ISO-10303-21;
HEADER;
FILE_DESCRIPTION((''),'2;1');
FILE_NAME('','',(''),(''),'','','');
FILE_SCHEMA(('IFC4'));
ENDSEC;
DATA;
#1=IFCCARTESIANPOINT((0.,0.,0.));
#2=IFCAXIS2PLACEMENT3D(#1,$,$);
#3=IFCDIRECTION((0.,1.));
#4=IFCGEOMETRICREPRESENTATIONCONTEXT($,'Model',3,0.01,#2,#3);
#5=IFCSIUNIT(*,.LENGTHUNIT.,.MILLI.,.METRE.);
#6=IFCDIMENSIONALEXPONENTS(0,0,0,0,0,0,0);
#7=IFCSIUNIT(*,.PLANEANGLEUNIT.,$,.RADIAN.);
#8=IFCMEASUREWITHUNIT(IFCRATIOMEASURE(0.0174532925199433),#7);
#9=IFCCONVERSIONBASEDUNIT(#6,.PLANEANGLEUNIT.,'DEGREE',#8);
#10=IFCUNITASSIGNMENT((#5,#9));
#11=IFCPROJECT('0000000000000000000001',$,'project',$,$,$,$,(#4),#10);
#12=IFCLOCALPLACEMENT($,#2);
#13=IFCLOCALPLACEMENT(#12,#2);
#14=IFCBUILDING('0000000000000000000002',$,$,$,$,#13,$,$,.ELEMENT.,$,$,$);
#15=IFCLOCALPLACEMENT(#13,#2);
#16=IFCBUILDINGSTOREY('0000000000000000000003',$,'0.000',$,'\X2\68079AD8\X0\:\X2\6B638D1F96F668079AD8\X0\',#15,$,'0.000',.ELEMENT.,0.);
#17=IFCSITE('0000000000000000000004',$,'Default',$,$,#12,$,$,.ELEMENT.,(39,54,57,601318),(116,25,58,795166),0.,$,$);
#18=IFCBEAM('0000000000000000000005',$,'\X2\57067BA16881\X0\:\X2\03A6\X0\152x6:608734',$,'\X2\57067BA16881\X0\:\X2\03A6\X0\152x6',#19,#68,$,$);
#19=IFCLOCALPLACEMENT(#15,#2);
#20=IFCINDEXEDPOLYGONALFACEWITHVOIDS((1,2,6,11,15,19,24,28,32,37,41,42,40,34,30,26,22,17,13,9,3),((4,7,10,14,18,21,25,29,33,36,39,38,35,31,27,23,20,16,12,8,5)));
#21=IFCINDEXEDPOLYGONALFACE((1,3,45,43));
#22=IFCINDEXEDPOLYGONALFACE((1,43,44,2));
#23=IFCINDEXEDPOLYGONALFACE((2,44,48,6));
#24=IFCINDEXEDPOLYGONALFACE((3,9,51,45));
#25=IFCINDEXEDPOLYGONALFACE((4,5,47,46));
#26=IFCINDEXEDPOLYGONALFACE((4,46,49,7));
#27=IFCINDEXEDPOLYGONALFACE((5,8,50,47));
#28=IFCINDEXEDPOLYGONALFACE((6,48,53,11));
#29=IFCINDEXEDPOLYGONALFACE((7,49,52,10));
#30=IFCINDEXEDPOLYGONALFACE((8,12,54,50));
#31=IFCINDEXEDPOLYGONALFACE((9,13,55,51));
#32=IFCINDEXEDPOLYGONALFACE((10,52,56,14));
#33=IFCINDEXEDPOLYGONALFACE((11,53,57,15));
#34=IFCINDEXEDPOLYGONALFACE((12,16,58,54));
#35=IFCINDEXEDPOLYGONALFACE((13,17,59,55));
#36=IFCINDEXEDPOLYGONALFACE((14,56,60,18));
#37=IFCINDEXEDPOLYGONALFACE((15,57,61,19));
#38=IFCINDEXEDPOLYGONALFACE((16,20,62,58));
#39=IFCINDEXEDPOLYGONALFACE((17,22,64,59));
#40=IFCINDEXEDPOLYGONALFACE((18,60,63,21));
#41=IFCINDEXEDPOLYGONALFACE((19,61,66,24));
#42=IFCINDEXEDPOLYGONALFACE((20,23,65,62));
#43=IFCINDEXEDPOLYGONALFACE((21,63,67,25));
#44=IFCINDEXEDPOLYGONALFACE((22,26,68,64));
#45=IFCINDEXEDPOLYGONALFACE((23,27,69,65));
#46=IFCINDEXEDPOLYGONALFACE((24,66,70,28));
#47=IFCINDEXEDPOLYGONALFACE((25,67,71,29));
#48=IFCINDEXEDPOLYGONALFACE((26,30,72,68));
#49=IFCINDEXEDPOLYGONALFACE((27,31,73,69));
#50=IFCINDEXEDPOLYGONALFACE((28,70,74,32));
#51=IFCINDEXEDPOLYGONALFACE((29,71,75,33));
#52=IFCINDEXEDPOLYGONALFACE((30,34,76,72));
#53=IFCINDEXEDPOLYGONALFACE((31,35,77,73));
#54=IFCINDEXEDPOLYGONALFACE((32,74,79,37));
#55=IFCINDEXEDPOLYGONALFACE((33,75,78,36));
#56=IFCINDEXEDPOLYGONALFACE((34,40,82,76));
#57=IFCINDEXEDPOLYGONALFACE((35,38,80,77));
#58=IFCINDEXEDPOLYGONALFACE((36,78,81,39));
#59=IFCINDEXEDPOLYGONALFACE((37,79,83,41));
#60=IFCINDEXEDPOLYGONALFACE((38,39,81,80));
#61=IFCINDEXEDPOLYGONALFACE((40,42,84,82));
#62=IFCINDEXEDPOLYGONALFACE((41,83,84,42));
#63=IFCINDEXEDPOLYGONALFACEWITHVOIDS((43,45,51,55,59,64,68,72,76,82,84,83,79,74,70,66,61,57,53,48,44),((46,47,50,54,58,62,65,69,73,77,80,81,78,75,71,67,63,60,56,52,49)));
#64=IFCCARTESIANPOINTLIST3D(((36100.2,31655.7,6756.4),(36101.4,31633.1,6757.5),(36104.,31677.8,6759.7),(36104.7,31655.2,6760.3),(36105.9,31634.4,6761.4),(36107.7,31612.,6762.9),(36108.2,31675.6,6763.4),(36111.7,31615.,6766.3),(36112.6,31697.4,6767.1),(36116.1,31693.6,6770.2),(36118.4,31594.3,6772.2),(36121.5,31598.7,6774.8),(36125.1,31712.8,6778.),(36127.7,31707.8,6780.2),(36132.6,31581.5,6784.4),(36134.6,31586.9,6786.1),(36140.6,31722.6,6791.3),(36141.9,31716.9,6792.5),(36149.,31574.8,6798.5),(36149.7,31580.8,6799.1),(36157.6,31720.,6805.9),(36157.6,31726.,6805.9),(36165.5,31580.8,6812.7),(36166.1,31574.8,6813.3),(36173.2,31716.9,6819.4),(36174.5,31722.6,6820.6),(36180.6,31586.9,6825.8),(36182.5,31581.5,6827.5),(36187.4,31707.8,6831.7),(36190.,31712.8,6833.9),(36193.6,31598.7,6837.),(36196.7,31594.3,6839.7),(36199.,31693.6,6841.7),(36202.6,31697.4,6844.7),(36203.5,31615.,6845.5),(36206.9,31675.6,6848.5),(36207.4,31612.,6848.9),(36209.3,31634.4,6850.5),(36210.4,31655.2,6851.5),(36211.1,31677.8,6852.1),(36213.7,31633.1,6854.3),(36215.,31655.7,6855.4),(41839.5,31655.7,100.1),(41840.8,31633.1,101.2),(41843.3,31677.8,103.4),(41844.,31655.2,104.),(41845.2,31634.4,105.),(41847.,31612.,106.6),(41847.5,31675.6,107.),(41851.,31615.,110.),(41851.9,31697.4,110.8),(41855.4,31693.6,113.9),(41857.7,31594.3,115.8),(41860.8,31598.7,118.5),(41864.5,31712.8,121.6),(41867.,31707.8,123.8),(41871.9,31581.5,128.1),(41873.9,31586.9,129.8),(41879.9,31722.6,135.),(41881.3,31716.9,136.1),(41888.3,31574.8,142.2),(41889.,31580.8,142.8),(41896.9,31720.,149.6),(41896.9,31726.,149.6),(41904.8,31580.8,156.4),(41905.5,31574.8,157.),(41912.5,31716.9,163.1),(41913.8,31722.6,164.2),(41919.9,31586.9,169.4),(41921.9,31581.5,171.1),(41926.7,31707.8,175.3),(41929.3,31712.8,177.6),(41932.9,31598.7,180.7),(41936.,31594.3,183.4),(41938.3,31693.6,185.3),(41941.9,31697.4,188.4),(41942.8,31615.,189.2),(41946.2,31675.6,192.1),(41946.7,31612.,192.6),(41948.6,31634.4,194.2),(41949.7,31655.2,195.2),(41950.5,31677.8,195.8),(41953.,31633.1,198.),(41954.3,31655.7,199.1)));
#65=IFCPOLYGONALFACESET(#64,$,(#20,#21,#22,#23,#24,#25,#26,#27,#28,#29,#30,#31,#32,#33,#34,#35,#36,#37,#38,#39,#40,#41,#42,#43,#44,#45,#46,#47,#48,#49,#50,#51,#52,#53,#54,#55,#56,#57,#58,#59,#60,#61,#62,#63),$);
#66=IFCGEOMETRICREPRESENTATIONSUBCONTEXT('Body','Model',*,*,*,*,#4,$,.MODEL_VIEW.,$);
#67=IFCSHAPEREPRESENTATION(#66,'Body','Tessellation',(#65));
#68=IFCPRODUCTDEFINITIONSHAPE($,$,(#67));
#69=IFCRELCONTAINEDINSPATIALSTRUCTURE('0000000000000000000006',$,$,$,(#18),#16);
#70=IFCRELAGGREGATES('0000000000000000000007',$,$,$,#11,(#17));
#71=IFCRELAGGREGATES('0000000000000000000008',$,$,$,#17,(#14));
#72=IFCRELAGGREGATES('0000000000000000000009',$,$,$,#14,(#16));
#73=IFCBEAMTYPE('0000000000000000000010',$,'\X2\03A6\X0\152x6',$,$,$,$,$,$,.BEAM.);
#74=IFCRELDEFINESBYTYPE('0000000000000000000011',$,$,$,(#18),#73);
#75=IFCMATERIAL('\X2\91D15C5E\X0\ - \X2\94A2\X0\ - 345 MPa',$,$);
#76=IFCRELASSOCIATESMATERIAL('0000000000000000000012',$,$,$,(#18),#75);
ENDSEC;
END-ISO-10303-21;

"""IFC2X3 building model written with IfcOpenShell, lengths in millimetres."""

from ifc_helpers import new_model, entity, si_unit, converted_unit, direction, frame, frame_2d, origin, place, context, subcontext, project, spatial, hollow_circle, extrude, material, type_object, element, save


model = new_model("IFC2X3")

# Units and contexts
model_context = context("Model", 3, precision=0.01, world=origin(), true_north=direction((0.0, 1.0)))
body_context = subcontext(model_context, "Body", "Model", "MODEL_VIEW")
ifc_project = project(units=[si_unit("LENGTHUNIT", "METRE", prefix="MILLI"), converted_unit("PLANEANGLEUNIT", "DEGREE", entity("IfcRatioMeasure", 0.0174532925199433), si_unit("PLANEANGLEUNIT", "RADIAN"), dimensions=[0, 0, 0, 0, 0, 0, 0])], contexts=[model_context])

# Site, building, storey
site_placement = place(None, origin())
site = spatial("IfcSite", under=ifc_project, at=site_placement, Name="Default", CompositionType="ELEMENT", RefLatitude=(39, 54, 57, 601318), RefLongitude=(116, 25, 58, 795166), RefElevation=0.0)
building_placement = place(site_placement, origin())
building = spatial("IfcBuilding", under=site, at=building_placement, CompositionType="ELEMENT")
storey_placement = place(building_placement, origin())
storey = spatial("IfcBuildingStorey", under=building, at=storey_placement, Name="0.000", ObjectType="标高:正负零标高", LongName="0.000", CompositionType="ELEMENT", Elevation=0.0)

# Shared definitions
ifc_material_1 = material(Name="金属 - 钢 - 345 MPa")

# Beam
beam_type_1 = type_object("IfcBeamType", Name="Φ152x6", PredefinedType="BEAM")
beam_1_placement = place(storey_placement, frame((41861.8, 31650.0, -116.0), z_axis=(0.757348, 0.0, 0.653011), x_axis=(-0.653011, 0.0, 0.757348)))
element("IfcBeam", 1, at=beam_1_placement, inside=storey, type_object=beam_type_1, material=ifc_material_1, Name="圆管梁:Φ152x6:608734", ObjectType="圆管梁:Φ152x6", context=body_context, shape_type="SweptSolid", body=[
    extrude(hollow_circle(Radius=76.0, WallThickness=6.0, at=frame_2d((0.0, 0.0), x_axis=(1.0, 0.0))), frame((178.3, 0.0, 200.0), z_axis=(1.0, 0.0, 0.0), x_axis=(0.0, -1.0, 0.0)), (0.0, 0.0, 1.0), 8789.0),
])

save(model, "model.ifc")
